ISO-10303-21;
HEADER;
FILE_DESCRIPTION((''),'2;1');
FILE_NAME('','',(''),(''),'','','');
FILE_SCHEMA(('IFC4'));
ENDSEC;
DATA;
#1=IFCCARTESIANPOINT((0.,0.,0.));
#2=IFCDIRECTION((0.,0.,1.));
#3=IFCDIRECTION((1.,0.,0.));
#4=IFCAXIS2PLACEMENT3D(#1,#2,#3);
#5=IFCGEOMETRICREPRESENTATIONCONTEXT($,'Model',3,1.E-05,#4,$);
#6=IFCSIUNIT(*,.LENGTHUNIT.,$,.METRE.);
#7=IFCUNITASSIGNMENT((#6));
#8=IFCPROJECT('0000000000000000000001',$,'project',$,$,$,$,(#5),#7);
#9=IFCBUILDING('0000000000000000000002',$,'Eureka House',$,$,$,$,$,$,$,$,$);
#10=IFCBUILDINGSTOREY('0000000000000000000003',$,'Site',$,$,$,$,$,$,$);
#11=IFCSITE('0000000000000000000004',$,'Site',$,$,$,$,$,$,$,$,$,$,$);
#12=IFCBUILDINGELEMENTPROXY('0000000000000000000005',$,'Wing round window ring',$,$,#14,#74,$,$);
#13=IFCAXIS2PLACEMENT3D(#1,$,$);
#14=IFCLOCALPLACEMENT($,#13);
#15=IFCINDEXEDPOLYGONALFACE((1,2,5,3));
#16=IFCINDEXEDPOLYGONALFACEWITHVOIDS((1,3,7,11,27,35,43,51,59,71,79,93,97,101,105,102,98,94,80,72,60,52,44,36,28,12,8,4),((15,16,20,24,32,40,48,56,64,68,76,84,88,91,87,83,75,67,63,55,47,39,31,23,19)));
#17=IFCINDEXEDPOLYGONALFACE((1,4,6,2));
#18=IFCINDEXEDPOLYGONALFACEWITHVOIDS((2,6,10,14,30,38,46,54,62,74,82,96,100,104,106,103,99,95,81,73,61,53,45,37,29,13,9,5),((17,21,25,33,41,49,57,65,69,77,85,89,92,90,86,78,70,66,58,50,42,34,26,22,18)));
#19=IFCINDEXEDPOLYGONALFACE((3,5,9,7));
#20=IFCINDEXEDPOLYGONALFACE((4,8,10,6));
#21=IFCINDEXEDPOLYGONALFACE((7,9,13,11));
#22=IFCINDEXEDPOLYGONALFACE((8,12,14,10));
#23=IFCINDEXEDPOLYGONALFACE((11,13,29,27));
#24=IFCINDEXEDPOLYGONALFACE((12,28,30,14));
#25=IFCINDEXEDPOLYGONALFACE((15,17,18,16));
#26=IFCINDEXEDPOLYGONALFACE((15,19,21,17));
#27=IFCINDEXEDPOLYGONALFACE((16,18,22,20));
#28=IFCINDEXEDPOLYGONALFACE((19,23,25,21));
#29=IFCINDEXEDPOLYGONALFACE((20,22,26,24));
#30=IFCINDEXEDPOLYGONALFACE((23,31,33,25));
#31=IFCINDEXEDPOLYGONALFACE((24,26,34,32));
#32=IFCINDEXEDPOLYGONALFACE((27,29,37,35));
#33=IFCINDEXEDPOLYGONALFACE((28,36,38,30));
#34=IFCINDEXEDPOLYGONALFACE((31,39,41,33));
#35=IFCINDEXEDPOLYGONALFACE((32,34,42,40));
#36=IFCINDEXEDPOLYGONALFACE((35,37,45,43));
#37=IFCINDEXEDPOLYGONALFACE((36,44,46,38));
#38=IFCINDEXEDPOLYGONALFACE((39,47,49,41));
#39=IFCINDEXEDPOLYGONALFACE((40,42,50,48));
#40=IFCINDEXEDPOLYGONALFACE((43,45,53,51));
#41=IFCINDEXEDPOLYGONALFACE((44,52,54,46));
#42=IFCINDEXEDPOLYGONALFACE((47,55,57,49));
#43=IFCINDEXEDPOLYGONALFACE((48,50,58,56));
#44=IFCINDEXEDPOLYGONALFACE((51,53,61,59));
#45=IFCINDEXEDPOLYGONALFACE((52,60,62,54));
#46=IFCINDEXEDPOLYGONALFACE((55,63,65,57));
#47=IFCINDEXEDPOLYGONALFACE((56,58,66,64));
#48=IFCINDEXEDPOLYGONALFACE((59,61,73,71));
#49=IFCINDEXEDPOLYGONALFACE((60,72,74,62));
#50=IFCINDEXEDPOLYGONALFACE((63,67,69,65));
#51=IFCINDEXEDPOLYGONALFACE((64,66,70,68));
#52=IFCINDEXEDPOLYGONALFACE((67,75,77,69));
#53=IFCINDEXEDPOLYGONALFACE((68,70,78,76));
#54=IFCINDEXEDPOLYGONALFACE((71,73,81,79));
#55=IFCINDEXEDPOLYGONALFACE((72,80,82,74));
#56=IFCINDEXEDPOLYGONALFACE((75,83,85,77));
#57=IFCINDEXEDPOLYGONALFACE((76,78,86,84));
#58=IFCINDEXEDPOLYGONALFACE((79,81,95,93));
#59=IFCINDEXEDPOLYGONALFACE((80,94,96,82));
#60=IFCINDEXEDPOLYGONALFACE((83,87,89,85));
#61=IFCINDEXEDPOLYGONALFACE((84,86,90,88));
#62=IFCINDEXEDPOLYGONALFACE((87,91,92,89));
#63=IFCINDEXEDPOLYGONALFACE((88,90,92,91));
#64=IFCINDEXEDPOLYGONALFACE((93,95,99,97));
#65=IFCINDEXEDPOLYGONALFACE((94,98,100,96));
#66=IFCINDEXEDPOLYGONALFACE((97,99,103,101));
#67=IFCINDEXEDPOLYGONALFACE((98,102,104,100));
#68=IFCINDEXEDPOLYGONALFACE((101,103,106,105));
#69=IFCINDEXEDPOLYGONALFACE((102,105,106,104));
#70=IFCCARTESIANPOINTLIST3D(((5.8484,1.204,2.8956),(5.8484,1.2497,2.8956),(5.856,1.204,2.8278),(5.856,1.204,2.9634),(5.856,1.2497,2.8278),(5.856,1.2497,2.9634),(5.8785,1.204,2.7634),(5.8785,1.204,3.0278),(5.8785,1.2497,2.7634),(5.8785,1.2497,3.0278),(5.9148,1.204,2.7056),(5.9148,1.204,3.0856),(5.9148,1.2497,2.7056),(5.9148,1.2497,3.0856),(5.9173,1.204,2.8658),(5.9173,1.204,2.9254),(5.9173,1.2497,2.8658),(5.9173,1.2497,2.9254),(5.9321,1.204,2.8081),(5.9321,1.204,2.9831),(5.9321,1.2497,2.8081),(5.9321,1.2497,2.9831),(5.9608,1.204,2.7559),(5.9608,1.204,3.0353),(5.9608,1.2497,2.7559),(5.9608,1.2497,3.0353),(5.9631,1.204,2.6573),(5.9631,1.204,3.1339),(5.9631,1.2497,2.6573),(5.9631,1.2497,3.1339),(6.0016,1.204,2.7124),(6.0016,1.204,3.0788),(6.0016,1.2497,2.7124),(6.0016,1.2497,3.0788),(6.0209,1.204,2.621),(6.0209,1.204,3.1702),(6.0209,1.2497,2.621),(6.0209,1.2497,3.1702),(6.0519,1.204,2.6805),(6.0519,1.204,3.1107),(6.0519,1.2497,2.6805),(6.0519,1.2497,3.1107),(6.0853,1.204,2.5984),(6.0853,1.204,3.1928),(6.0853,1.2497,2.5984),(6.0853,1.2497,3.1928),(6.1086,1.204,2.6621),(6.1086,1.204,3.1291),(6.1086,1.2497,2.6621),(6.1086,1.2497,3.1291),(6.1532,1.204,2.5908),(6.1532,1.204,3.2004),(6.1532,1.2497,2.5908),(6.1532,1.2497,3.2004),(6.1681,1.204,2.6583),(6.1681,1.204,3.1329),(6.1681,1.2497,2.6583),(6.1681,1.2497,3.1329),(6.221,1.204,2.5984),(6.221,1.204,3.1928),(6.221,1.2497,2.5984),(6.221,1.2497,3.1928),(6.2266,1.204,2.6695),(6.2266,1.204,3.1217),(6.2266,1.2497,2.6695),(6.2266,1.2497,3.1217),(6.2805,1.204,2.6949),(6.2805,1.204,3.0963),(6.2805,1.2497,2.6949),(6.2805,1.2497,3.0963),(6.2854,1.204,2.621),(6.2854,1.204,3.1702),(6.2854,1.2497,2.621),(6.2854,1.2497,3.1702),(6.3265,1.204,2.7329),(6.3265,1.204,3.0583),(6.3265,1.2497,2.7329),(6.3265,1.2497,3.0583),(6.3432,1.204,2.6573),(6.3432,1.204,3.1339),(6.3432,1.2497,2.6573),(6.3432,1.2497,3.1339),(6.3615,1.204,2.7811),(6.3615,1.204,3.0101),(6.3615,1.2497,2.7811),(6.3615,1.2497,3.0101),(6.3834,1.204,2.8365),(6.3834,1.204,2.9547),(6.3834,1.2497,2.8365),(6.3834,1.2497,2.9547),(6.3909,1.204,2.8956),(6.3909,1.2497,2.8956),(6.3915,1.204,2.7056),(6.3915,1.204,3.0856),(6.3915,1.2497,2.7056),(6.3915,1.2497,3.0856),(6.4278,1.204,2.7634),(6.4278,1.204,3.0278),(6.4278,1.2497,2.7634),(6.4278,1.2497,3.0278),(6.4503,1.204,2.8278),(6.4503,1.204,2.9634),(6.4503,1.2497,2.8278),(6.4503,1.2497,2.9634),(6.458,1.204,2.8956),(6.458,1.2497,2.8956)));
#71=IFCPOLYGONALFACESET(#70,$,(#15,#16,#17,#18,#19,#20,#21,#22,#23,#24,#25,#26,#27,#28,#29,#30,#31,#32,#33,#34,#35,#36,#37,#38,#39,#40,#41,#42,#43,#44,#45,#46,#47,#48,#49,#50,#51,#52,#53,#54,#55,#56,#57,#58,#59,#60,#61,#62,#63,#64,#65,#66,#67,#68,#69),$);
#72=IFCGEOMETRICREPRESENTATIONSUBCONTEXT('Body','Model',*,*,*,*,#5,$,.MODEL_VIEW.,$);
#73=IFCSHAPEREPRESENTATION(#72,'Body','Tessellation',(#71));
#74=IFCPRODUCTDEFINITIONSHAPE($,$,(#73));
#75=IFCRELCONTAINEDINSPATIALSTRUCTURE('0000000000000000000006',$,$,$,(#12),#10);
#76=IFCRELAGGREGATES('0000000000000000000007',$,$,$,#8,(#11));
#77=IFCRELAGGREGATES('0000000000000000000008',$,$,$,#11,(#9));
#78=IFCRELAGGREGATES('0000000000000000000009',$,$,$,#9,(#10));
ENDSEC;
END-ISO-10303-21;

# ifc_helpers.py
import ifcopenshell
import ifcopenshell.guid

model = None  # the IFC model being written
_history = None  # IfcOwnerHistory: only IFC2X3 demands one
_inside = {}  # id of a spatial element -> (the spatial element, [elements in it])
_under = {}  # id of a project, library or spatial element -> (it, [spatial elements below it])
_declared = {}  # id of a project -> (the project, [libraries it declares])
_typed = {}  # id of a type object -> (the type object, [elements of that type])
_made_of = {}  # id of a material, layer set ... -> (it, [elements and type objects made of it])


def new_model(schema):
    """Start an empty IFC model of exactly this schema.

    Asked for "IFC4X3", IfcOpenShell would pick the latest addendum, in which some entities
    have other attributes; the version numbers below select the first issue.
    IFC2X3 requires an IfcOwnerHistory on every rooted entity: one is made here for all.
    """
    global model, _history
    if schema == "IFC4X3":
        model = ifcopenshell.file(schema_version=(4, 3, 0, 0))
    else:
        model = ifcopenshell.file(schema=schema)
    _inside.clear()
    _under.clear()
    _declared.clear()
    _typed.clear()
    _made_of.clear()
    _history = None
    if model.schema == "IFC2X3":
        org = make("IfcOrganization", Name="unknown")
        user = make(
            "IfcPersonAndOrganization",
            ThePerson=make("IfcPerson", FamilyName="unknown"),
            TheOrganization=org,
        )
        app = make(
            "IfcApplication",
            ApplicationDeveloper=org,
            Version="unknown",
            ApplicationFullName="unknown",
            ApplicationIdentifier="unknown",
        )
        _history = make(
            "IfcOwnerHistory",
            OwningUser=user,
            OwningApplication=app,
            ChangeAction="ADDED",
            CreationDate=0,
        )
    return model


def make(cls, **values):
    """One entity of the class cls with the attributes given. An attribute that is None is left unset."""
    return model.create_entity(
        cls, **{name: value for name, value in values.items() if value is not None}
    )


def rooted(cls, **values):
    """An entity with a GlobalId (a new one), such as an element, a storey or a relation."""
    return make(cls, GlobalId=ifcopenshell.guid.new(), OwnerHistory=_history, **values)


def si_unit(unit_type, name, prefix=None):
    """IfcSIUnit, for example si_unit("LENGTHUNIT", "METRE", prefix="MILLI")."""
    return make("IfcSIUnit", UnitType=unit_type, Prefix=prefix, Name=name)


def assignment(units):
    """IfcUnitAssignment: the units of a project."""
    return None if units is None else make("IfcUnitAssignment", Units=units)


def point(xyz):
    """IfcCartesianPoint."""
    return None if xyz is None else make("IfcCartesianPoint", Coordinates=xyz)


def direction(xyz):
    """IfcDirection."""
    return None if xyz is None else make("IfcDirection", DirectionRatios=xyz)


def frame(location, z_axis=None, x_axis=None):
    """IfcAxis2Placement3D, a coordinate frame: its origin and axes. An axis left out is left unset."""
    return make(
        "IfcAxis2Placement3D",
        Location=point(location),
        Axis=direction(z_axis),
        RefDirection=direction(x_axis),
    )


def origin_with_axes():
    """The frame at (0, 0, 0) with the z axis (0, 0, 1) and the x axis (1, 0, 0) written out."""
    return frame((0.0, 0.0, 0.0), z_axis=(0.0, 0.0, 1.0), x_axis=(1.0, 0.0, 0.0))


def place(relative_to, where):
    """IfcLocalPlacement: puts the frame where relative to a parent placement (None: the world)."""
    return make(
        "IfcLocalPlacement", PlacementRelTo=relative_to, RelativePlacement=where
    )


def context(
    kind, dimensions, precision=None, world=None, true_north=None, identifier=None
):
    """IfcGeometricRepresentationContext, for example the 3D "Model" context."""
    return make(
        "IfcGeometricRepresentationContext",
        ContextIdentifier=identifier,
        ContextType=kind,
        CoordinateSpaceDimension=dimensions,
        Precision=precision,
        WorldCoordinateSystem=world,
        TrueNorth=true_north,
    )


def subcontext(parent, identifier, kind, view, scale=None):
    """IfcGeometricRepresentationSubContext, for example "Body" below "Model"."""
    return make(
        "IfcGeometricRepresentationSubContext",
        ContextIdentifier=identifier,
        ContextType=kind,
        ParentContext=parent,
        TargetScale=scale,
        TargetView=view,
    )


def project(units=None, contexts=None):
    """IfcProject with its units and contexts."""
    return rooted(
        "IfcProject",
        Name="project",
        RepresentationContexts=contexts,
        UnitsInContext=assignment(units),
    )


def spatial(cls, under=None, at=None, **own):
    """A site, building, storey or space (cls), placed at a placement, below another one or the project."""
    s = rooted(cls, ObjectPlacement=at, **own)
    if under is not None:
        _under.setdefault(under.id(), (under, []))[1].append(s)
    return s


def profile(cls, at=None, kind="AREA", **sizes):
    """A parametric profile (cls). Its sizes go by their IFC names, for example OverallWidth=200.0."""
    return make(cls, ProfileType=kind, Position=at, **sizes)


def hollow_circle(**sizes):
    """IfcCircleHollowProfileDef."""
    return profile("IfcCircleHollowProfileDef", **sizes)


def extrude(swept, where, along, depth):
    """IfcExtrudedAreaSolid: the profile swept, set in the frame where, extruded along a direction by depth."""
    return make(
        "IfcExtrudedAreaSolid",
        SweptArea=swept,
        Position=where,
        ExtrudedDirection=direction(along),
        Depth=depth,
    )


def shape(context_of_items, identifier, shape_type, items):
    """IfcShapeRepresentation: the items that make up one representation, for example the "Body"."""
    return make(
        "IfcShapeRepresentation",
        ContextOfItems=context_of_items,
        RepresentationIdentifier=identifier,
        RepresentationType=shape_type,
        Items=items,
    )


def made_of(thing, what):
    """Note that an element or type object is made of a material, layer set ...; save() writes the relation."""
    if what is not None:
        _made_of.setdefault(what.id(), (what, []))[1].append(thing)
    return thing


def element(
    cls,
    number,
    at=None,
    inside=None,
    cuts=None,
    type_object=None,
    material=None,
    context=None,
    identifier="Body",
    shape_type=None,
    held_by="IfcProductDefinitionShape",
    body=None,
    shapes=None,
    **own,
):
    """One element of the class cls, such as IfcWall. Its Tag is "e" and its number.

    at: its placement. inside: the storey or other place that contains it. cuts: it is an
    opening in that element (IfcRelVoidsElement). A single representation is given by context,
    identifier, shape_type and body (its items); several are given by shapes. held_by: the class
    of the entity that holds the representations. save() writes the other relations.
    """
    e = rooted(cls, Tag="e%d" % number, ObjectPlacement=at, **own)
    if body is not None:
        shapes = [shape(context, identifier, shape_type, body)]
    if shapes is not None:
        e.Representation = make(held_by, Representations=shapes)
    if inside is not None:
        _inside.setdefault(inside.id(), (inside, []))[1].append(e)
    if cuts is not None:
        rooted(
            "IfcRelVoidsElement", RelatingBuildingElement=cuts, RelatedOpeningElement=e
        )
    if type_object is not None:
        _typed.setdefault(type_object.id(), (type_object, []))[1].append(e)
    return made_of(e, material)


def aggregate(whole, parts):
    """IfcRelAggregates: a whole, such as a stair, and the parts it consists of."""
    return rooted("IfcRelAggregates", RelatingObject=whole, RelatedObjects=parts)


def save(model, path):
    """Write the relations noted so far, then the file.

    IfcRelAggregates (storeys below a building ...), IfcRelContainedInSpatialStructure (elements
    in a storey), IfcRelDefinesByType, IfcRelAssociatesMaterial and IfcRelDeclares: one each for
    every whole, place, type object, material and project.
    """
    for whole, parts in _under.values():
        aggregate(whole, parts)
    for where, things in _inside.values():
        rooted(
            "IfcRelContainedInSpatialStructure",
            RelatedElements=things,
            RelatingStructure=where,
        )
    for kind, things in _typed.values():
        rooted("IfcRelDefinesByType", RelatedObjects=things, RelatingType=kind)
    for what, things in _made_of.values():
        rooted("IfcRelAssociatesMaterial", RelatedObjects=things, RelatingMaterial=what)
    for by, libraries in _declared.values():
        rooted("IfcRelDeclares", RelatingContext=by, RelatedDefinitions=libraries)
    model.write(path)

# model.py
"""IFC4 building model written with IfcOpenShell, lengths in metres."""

from ifc_helpers import new_model, si_unit, frame, origin_with_axes, place, context, subcontext, project, spatial, hollow_circle, extrude, element, save


model = new_model("IFC4")

# Units and contexts
model_context = context("Model", 3, precision=1e-05, world=origin_with_axes())
body_context = subcontext(model_context, "Body", "Model", "MODEL_VIEW")
ifc_project = project(units=[si_unit("LENGTHUNIT", "METRE")], contexts=[model_context])

# Site, building, storey
site = spatial("IfcSite", under=ifc_project, Name="Site")
building = spatial("IfcBuilding", under=site, Name="Eureka House")
storey = spatial("IfcBuildingStorey", under=building, Name="Site")

# Building element proxy
proxy_1_placement = place(None, origin_with_axes())
element("IfcBuildingElementProxy", 1, at=proxy_1_placement, inside=storey, Name="Wing round window ring", context=body_context, shape_type="SweptSolid", body=[
    extrude(hollow_circle(Radius=0.3048, WallThickness=0.0671), frame((6.1532, 1.204, 2.8956), z_axis=(0.0, 1.0, 0.0), x_axis=(1.0, 0.0, 0.0)), (0.0, 0.0, 1.0), 0.0457),
])

save(model, "model.ifc")
